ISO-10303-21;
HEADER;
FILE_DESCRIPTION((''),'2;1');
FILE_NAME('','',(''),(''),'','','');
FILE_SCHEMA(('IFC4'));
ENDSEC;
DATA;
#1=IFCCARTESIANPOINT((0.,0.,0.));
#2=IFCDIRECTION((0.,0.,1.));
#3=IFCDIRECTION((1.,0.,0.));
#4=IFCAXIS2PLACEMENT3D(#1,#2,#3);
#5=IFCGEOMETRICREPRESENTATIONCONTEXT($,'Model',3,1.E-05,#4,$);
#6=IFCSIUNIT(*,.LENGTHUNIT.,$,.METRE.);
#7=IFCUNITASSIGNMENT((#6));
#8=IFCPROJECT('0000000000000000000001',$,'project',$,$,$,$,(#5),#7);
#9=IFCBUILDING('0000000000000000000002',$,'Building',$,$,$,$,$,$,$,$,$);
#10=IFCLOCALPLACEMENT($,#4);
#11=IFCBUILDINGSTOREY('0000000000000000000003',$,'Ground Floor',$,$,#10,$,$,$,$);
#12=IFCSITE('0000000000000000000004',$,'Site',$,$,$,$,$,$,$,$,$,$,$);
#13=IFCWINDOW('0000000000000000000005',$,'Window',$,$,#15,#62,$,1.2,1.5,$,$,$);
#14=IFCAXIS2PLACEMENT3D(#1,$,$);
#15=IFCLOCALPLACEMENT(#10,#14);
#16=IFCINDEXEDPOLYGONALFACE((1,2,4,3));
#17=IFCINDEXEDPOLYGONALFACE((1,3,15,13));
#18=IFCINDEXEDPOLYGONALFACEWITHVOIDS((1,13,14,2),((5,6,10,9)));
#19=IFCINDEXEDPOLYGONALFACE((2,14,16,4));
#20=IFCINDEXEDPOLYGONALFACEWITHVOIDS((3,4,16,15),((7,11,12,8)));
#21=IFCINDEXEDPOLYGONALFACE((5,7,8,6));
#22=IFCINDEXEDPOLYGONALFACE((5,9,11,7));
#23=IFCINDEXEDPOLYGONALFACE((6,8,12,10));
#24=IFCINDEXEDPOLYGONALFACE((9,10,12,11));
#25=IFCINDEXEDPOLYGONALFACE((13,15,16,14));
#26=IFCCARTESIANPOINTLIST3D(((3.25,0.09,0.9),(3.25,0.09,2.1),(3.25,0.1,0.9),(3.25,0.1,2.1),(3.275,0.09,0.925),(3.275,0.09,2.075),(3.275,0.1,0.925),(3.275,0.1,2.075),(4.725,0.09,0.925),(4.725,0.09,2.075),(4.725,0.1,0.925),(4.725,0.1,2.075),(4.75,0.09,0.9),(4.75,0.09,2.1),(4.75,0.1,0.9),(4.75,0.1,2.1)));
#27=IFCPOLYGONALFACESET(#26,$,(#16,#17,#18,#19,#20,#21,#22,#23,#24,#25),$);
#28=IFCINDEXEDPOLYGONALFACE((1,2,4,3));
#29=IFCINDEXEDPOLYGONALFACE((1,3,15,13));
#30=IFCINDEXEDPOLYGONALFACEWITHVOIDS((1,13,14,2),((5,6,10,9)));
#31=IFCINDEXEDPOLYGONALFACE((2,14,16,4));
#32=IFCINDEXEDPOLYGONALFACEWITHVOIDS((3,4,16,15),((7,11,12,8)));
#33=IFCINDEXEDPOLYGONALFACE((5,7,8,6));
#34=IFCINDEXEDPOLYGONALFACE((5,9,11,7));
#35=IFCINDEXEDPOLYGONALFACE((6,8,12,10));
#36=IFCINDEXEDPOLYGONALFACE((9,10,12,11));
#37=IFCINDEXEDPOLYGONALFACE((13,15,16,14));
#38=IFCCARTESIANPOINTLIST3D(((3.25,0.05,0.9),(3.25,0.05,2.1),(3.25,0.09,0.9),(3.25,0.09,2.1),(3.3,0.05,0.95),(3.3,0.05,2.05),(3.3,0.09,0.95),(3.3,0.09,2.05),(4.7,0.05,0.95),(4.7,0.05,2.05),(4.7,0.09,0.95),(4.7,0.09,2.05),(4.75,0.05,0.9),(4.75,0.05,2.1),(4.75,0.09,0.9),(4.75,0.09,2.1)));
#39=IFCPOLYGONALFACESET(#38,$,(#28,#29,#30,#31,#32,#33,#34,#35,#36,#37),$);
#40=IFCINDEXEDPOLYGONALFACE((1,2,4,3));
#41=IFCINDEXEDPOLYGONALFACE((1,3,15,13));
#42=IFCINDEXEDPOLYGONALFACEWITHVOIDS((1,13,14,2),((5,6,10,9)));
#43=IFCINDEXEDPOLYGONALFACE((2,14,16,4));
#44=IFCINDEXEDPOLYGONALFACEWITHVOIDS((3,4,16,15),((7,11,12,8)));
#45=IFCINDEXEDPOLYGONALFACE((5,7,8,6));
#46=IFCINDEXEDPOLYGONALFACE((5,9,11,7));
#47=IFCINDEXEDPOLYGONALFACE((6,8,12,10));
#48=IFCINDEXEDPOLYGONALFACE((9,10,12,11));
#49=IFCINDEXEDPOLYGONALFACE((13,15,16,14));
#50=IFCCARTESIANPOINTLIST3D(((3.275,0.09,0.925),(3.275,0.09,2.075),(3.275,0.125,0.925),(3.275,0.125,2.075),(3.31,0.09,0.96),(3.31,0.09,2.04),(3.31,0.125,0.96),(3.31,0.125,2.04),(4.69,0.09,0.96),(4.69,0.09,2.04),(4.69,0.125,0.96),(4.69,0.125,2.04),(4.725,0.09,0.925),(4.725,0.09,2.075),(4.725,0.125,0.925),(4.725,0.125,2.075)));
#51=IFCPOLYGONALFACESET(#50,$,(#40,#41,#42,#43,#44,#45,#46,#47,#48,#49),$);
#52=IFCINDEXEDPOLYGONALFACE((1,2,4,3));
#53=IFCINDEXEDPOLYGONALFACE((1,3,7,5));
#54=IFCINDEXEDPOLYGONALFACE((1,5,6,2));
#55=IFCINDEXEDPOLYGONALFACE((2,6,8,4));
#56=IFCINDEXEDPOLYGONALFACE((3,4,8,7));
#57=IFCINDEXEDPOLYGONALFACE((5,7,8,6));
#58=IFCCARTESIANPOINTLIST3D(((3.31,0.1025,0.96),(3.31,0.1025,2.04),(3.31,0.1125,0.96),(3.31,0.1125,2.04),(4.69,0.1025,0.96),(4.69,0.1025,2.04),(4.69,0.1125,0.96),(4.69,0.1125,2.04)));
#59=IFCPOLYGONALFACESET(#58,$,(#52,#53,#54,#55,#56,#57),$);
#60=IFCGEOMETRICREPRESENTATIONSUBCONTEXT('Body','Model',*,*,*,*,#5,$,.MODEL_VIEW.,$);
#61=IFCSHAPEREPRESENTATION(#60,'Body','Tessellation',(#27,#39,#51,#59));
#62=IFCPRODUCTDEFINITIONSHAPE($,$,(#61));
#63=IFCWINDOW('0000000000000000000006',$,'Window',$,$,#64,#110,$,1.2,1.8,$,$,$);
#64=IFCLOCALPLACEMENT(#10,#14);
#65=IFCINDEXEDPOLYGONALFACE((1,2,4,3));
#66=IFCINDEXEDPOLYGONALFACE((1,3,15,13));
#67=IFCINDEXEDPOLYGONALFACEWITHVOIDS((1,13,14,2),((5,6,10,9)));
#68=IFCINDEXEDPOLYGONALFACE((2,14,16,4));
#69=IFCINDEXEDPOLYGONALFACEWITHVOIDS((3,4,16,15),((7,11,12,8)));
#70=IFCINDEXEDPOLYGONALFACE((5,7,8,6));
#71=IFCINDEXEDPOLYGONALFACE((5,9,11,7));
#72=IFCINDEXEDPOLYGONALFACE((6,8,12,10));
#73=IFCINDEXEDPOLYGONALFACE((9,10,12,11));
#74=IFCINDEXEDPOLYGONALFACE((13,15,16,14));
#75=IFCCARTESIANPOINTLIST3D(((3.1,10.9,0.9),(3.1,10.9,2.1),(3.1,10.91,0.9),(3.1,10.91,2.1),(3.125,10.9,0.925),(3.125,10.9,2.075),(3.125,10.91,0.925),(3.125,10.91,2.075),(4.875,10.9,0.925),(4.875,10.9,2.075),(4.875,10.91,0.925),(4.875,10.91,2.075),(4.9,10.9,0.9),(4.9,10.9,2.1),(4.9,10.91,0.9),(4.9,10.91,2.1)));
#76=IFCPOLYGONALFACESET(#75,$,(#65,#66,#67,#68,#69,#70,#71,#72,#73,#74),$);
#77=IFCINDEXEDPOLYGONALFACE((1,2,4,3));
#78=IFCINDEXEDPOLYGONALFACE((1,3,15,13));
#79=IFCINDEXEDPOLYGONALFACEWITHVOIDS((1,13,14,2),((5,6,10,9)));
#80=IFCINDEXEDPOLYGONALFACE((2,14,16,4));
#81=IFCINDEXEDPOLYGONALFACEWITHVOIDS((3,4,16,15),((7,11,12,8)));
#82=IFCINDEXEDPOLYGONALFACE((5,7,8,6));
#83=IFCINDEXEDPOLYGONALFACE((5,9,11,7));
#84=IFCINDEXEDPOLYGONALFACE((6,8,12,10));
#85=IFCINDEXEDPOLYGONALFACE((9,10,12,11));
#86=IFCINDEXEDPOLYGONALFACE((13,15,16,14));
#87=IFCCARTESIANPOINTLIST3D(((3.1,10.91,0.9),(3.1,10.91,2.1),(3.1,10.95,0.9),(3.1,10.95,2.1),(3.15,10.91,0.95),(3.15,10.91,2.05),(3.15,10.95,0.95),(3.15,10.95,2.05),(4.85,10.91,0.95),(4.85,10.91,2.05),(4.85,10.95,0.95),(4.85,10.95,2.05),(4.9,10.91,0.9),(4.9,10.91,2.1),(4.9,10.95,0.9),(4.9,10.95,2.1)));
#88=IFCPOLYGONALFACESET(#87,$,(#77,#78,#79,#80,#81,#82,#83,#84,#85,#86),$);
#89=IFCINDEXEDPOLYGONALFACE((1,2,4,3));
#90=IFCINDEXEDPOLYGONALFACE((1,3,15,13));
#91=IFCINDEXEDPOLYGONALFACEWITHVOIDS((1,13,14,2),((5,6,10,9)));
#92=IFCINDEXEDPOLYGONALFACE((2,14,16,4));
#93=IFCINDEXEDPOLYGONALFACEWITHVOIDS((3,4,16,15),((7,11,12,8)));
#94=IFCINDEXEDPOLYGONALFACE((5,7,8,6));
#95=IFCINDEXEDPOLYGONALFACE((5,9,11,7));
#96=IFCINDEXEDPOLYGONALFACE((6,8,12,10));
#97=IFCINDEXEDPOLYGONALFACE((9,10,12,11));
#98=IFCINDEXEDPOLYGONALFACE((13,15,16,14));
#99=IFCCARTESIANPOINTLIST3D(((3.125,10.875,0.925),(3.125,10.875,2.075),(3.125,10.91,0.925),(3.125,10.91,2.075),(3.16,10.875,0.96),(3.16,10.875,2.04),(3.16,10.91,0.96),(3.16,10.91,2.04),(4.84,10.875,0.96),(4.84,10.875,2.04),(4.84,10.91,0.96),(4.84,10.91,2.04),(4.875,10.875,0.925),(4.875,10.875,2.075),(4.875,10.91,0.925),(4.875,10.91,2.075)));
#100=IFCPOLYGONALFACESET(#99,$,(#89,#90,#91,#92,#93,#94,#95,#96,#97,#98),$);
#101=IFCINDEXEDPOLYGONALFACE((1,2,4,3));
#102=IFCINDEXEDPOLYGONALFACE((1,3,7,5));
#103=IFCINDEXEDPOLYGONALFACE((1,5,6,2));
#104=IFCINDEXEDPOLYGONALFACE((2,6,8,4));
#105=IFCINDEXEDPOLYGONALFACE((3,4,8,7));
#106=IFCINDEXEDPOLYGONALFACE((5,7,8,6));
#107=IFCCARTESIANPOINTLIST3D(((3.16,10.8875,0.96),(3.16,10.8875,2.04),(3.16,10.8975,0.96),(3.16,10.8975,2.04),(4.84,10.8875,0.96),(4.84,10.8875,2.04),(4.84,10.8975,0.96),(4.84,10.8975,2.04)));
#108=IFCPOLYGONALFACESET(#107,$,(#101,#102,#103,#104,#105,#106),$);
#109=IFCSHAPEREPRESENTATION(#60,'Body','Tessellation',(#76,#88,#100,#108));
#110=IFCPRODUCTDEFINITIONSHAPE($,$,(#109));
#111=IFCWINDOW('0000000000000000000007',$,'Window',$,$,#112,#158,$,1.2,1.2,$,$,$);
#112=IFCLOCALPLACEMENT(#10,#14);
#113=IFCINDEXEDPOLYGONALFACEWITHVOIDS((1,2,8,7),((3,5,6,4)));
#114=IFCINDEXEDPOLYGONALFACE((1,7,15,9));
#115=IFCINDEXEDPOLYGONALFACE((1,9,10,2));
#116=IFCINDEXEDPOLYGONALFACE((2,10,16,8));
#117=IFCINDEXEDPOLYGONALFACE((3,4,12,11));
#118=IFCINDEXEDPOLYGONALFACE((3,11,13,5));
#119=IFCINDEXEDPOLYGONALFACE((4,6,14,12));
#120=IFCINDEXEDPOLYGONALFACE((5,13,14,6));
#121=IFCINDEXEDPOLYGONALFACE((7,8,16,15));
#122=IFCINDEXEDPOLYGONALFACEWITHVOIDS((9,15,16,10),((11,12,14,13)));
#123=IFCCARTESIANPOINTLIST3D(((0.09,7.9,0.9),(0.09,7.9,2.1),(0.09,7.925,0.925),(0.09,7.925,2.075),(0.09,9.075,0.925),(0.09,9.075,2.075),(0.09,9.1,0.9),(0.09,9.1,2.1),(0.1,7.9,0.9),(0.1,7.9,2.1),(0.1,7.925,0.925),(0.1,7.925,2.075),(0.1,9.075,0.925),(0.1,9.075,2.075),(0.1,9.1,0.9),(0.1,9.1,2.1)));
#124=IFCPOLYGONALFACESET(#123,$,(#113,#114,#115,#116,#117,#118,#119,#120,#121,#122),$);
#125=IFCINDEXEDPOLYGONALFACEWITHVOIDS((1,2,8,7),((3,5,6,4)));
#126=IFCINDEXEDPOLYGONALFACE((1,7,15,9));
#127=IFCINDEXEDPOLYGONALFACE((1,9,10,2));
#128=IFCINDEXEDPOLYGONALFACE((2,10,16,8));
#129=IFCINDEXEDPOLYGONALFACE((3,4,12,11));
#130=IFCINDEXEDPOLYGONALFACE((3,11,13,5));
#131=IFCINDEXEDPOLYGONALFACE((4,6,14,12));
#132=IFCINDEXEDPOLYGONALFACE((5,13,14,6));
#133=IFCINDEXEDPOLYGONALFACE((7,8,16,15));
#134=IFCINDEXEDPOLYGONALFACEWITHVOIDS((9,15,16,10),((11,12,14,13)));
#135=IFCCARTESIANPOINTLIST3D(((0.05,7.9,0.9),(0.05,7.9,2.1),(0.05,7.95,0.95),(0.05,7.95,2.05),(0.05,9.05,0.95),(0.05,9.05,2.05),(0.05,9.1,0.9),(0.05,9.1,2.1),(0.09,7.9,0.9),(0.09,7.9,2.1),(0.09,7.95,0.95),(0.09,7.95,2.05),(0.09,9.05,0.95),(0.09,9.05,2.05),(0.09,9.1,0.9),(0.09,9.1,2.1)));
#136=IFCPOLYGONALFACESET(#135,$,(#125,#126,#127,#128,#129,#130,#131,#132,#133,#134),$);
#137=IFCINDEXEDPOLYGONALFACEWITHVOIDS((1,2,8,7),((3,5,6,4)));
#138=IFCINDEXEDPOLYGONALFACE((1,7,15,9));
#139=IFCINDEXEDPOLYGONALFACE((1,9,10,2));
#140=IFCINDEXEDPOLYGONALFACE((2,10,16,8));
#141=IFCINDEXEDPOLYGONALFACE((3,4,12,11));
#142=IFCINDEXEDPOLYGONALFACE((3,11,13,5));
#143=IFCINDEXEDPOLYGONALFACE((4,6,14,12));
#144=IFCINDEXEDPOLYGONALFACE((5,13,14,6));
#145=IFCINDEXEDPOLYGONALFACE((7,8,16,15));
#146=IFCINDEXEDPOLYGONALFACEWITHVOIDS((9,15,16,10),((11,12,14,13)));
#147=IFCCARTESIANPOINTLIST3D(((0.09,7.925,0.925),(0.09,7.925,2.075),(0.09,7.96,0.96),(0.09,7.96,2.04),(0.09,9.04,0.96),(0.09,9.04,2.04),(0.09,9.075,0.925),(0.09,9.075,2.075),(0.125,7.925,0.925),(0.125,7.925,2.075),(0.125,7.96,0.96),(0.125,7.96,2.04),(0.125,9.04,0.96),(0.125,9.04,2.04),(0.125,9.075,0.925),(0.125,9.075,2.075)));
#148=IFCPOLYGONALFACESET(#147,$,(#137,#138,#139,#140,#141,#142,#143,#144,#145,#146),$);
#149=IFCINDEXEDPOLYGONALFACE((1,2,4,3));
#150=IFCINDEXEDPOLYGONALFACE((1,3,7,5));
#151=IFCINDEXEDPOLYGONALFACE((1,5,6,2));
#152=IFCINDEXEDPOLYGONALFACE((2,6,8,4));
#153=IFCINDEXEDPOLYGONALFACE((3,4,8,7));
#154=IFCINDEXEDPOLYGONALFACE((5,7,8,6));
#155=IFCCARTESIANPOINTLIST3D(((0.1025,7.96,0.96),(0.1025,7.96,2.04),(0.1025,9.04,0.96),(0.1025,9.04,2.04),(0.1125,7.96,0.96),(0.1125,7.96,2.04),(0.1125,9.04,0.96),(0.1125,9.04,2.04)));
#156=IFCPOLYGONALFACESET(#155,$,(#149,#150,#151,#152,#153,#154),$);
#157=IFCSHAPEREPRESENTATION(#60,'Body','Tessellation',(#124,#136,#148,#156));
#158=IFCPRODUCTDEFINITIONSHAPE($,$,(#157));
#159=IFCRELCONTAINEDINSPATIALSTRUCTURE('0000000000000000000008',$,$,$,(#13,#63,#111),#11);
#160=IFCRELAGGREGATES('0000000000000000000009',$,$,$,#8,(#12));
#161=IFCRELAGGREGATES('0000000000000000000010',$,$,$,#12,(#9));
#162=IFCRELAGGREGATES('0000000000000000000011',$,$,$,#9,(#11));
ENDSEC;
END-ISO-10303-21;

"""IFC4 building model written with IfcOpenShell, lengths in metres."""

from ifc_helpers import new_model, si_unit, frame, origin_with_axes, place, context, subcontext, project, spatial, line, indexed_curve, outline, extrude, element, save


model = new_model("IFC4")

# Units and contexts
model_context = context("Model", 3, precision=1e-05, world=origin_with_axes())
body_context = subcontext(model_context, "Body", "Model", "MODEL_VIEW")
ifc_project = project(units=[si_unit("LENGTHUNIT", "METRE")], contexts=[model_context])

# Site, building, storey
site = spatial("IfcSite", under=ifc_project, Name="Site")
building = spatial("IfcBuilding", under=site, Name="Building")
storey_placement = place(None, origin_with_axes())
storey = spatial("IfcBuildingStorey", under=building, at=storey_placement, Name="Ground Floor")

# Windows
window_1_placement = place(storey_placement, frame((3.25, 0.0, 0.9), z_axis=(0.0, 0.0, 1.0), x_axis=(1.0, 0.0, 0.0)))
element("IfcWindow", 1, at=window_1_placement, inside=storey, Name="Window", OverallHeight=1.2, OverallWidth=1.5, context=body_context, shape_type="SweptSolid", body=[
    extrude(outline(indexed_curve([(0.0, 0.0), (1.5, 0.0), (1.5, 1.2), (0.0, 1.2)], segments=[line(1, 2, 3, 4, 1)]), holes=[indexed_curve([(0.025, 0.025), (1.475, 0.025), (1.475, 1.175), (0.025, 1.175)], segments=[line(1, 2, 3, 4, 1)])]), frame((0.0, 0.09, 0.0), z_axis=(0.0, -1.0, 0.0), x_axis=(1.0, 0.0, 0.0)), (0.0, 0.0, -1.0), 0.01),
    extrude(outline(indexed_curve([(0.0, 0.0), (1.5, 0.0), (1.5, 1.2), (0.0, 1.2)], segments=[line(1, 2, 3, 4, 1)]), holes=[indexed_curve([(0.05, 0.05), (1.45, 0.05), (1.45, 1.15), (0.05, 1.15)], segments=[line(1, 2, 3, 4, 1)])]), frame((0.0, 0.05, 0.0), z_axis=(0.0, -1.0, 0.0), x_axis=(1.0, 0.0, 0.0)), (0.0, 0.0, -1.0), 0.04),
    extrude(outline(indexed_curve([(0.0, 0.0), (1.45, 0.0), (1.45, 1.15), (0.0, 1.15)], segments=[line(1, 2, 3, 4, 1)]), holes=[indexed_curve([(0.035, 0.035), (1.415, 0.035), (1.415, 1.115), (0.035, 1.115)], segments=[line(1, 2, 3, 4, 1)])]), frame((0.025, 0.09, 0.025), z_axis=(0.0, -1.0, 0.0), x_axis=(1.0, 0.0, 0.0)), (0.0, 0.0, -1.0), 0.035),
    extrude(outline(indexed_curve([(0.035, 0.035), (1.415, 0.035), (1.415, 1.115), (0.035, 1.115)], segments=[line(1, 2, 3, 4, 1)])), frame((0.025, 0.1025, 0.025), z_axis=(0.0, -1.0, 0.0), x_axis=(1.0, 0.0, 0.0)), (0.0, 0.0, -1.0), 0.01),
])
window_2_placement = place(storey_placement, frame((4.9, 11.0, 0.9), z_axis=(0.0, 0.0, 1.0), x_axis=(-1.0, 0.0, 0.0)))
element("IfcWindow", 2, at=window_2_placement, inside=storey, Name="Window", OverallHeight=1.2, OverallWidth=1.8, context=body_context, shape_type="SweptSolid", body=[
    extrude(outline(indexed_curve([(0.0, 0.0), (1.8, 0.0), (1.8, 1.2), (0.0, 1.2)], segments=[line(1, 2, 3, 4, 1)]), holes=[indexed_curve([(0.025, 0.025), (1.775, 0.025), (1.775, 1.175), (0.025, 1.175)], segments=[line(1, 2, 3, 4, 1)])]), frame((0.0, 0.09, 0.0), z_axis=(0.0, -1.0, 0.0), x_axis=(1.0, 0.0, 0.0)), (0.0, 0.0, -1.0), 0.01),
    extrude(outline(indexed_curve([(0.0, 0.0), (1.8, 0.0), (1.8, 1.2), (0.0, 1.2)], segments=[line(1, 2, 3, 4, 1)]), holes=[indexed_curve([(0.05, 0.05), (1.75, 0.05), (1.75, 1.15), (0.05, 1.15)], segments=[line(1, 2, 3, 4, 1)])]), frame((0.0, 0.05, 0.0), z_axis=(0.0, -1.0, 0.0), x_axis=(1.0, 0.0, 0.0)), (0.0, 0.0, -1.0), 0.04),
    extrude(outline(indexed_curve([(0.0, 0.0), (1.75, 0.0), (1.75, 1.15), (0.0, 1.15)], segments=[line(1, 2, 3, 4, 1)]), holes=[indexed_curve([(0.035, 0.035), (1.715, 0.035), (1.715, 1.115), (0.035, 1.115)], segments=[line(1, 2, 3, 4, 1)])]), frame((0.025, 0.09, 0.025), z_axis=(0.0, -1.0, 0.0), x_axis=(1.0, 0.0, 0.0)), (0.0, 0.0, -1.0), 0.035),
    extrude(outline(indexed_curve([(0.035, 0.035), (1.715, 0.035), (1.715, 1.115), (0.035, 1.115)], segments=[line(1, 2, 3, 4, 1)])), frame((0.025, 0.1025, 0.025), z_axis=(0.0, -1.0, 0.0), x_axis=(1.0, 0.0, 0.0)), (0.0, 0.0, -1.0), 0.01),
])
window_3_placement = place(storey_placement, frame((0.0, 9.1, 0.9), z_axis=(0.0, 0.0, 1.0), x_axis=(0.0, -1.0, 0.0)))
element("IfcWindow", 3, at=window_3_placement, inside=storey, Name="Window", OverallHeight=1.2, OverallWidth=1.2, context=body_context, shape_type="SweptSolid", body=[
    extrude(outline(indexed_curve([(0.0, 0.0), (1.2, 0.0), (1.2, 1.2), (0.0, 1.2)], segments=[line(1, 2, 3, 4, 1)]), holes=[indexed_curve([(0.025, 0.025), (1.175, 0.025), (1.175, 1.175), (0.025, 1.175)], segments=[line(1, 2, 3, 4, 1)])]), frame((0.0, 0.09, 0.0), z_axis=(0.0, -1.0, 0.0), x_axis=(1.0, 0.0, 0.0)), (0.0, 0.0, -1.0), 0.01),
    extrude(outline(indexed_curve([(0.0, 0.0), (1.2, 0.0), (1.2, 1.2), (0.0, 1.2)], segments=[line(1, 2, 3, 4, 1)]), holes=[indexed_curve([(0.05, 0.05), (1.15, 0.05), (1.15, 1.15), (0.05, 1.15)], segments=[line(1, 2, 3, 4, 1)])]), frame((0.0, 0.05, 0.0), z_axis=(0.0, -1.0, 0.0), x_axis=(1.0, 0.0, 0.0)), (0.0, 0.0, -1.0), 0.04),
    extrude(outline(indexed_curve([(0.0, 0.0), (1.15, 0.0), (1.15, 1.15), (0.0, 1.15)], segments=[line(1, 2, 3, 4, 1)]), holes=[indexed_curve([(0.035, 0.035), (1.115, 0.035), (1.115, 1.115), (0.035, 1.115)], segments=[line(1, 2, 3, 4, 1)])]), frame((0.025, 0.09, 0.025), z_axis=(0.0, -1.0, 0.0), x_axis=(1.0, 0.0, 0.0)), (0.0, 0.0, -1.0), 0.035),
    extrude(outline(indexed_curve([(0.035, 0.035), (1.115, 0.035), (1.115, 1.115), (0.035, 1.115)], segments=[line(1, 2, 3, 4, 1)])), frame((0.025, 0.1025, 0.025), z_axis=(0.0, -1.0, 0.0), x_axis=(1.0, 0.0, 0.0)), (0.0, 0.0, -1.0), 0.01),
])

save(model, "model.ifc")
